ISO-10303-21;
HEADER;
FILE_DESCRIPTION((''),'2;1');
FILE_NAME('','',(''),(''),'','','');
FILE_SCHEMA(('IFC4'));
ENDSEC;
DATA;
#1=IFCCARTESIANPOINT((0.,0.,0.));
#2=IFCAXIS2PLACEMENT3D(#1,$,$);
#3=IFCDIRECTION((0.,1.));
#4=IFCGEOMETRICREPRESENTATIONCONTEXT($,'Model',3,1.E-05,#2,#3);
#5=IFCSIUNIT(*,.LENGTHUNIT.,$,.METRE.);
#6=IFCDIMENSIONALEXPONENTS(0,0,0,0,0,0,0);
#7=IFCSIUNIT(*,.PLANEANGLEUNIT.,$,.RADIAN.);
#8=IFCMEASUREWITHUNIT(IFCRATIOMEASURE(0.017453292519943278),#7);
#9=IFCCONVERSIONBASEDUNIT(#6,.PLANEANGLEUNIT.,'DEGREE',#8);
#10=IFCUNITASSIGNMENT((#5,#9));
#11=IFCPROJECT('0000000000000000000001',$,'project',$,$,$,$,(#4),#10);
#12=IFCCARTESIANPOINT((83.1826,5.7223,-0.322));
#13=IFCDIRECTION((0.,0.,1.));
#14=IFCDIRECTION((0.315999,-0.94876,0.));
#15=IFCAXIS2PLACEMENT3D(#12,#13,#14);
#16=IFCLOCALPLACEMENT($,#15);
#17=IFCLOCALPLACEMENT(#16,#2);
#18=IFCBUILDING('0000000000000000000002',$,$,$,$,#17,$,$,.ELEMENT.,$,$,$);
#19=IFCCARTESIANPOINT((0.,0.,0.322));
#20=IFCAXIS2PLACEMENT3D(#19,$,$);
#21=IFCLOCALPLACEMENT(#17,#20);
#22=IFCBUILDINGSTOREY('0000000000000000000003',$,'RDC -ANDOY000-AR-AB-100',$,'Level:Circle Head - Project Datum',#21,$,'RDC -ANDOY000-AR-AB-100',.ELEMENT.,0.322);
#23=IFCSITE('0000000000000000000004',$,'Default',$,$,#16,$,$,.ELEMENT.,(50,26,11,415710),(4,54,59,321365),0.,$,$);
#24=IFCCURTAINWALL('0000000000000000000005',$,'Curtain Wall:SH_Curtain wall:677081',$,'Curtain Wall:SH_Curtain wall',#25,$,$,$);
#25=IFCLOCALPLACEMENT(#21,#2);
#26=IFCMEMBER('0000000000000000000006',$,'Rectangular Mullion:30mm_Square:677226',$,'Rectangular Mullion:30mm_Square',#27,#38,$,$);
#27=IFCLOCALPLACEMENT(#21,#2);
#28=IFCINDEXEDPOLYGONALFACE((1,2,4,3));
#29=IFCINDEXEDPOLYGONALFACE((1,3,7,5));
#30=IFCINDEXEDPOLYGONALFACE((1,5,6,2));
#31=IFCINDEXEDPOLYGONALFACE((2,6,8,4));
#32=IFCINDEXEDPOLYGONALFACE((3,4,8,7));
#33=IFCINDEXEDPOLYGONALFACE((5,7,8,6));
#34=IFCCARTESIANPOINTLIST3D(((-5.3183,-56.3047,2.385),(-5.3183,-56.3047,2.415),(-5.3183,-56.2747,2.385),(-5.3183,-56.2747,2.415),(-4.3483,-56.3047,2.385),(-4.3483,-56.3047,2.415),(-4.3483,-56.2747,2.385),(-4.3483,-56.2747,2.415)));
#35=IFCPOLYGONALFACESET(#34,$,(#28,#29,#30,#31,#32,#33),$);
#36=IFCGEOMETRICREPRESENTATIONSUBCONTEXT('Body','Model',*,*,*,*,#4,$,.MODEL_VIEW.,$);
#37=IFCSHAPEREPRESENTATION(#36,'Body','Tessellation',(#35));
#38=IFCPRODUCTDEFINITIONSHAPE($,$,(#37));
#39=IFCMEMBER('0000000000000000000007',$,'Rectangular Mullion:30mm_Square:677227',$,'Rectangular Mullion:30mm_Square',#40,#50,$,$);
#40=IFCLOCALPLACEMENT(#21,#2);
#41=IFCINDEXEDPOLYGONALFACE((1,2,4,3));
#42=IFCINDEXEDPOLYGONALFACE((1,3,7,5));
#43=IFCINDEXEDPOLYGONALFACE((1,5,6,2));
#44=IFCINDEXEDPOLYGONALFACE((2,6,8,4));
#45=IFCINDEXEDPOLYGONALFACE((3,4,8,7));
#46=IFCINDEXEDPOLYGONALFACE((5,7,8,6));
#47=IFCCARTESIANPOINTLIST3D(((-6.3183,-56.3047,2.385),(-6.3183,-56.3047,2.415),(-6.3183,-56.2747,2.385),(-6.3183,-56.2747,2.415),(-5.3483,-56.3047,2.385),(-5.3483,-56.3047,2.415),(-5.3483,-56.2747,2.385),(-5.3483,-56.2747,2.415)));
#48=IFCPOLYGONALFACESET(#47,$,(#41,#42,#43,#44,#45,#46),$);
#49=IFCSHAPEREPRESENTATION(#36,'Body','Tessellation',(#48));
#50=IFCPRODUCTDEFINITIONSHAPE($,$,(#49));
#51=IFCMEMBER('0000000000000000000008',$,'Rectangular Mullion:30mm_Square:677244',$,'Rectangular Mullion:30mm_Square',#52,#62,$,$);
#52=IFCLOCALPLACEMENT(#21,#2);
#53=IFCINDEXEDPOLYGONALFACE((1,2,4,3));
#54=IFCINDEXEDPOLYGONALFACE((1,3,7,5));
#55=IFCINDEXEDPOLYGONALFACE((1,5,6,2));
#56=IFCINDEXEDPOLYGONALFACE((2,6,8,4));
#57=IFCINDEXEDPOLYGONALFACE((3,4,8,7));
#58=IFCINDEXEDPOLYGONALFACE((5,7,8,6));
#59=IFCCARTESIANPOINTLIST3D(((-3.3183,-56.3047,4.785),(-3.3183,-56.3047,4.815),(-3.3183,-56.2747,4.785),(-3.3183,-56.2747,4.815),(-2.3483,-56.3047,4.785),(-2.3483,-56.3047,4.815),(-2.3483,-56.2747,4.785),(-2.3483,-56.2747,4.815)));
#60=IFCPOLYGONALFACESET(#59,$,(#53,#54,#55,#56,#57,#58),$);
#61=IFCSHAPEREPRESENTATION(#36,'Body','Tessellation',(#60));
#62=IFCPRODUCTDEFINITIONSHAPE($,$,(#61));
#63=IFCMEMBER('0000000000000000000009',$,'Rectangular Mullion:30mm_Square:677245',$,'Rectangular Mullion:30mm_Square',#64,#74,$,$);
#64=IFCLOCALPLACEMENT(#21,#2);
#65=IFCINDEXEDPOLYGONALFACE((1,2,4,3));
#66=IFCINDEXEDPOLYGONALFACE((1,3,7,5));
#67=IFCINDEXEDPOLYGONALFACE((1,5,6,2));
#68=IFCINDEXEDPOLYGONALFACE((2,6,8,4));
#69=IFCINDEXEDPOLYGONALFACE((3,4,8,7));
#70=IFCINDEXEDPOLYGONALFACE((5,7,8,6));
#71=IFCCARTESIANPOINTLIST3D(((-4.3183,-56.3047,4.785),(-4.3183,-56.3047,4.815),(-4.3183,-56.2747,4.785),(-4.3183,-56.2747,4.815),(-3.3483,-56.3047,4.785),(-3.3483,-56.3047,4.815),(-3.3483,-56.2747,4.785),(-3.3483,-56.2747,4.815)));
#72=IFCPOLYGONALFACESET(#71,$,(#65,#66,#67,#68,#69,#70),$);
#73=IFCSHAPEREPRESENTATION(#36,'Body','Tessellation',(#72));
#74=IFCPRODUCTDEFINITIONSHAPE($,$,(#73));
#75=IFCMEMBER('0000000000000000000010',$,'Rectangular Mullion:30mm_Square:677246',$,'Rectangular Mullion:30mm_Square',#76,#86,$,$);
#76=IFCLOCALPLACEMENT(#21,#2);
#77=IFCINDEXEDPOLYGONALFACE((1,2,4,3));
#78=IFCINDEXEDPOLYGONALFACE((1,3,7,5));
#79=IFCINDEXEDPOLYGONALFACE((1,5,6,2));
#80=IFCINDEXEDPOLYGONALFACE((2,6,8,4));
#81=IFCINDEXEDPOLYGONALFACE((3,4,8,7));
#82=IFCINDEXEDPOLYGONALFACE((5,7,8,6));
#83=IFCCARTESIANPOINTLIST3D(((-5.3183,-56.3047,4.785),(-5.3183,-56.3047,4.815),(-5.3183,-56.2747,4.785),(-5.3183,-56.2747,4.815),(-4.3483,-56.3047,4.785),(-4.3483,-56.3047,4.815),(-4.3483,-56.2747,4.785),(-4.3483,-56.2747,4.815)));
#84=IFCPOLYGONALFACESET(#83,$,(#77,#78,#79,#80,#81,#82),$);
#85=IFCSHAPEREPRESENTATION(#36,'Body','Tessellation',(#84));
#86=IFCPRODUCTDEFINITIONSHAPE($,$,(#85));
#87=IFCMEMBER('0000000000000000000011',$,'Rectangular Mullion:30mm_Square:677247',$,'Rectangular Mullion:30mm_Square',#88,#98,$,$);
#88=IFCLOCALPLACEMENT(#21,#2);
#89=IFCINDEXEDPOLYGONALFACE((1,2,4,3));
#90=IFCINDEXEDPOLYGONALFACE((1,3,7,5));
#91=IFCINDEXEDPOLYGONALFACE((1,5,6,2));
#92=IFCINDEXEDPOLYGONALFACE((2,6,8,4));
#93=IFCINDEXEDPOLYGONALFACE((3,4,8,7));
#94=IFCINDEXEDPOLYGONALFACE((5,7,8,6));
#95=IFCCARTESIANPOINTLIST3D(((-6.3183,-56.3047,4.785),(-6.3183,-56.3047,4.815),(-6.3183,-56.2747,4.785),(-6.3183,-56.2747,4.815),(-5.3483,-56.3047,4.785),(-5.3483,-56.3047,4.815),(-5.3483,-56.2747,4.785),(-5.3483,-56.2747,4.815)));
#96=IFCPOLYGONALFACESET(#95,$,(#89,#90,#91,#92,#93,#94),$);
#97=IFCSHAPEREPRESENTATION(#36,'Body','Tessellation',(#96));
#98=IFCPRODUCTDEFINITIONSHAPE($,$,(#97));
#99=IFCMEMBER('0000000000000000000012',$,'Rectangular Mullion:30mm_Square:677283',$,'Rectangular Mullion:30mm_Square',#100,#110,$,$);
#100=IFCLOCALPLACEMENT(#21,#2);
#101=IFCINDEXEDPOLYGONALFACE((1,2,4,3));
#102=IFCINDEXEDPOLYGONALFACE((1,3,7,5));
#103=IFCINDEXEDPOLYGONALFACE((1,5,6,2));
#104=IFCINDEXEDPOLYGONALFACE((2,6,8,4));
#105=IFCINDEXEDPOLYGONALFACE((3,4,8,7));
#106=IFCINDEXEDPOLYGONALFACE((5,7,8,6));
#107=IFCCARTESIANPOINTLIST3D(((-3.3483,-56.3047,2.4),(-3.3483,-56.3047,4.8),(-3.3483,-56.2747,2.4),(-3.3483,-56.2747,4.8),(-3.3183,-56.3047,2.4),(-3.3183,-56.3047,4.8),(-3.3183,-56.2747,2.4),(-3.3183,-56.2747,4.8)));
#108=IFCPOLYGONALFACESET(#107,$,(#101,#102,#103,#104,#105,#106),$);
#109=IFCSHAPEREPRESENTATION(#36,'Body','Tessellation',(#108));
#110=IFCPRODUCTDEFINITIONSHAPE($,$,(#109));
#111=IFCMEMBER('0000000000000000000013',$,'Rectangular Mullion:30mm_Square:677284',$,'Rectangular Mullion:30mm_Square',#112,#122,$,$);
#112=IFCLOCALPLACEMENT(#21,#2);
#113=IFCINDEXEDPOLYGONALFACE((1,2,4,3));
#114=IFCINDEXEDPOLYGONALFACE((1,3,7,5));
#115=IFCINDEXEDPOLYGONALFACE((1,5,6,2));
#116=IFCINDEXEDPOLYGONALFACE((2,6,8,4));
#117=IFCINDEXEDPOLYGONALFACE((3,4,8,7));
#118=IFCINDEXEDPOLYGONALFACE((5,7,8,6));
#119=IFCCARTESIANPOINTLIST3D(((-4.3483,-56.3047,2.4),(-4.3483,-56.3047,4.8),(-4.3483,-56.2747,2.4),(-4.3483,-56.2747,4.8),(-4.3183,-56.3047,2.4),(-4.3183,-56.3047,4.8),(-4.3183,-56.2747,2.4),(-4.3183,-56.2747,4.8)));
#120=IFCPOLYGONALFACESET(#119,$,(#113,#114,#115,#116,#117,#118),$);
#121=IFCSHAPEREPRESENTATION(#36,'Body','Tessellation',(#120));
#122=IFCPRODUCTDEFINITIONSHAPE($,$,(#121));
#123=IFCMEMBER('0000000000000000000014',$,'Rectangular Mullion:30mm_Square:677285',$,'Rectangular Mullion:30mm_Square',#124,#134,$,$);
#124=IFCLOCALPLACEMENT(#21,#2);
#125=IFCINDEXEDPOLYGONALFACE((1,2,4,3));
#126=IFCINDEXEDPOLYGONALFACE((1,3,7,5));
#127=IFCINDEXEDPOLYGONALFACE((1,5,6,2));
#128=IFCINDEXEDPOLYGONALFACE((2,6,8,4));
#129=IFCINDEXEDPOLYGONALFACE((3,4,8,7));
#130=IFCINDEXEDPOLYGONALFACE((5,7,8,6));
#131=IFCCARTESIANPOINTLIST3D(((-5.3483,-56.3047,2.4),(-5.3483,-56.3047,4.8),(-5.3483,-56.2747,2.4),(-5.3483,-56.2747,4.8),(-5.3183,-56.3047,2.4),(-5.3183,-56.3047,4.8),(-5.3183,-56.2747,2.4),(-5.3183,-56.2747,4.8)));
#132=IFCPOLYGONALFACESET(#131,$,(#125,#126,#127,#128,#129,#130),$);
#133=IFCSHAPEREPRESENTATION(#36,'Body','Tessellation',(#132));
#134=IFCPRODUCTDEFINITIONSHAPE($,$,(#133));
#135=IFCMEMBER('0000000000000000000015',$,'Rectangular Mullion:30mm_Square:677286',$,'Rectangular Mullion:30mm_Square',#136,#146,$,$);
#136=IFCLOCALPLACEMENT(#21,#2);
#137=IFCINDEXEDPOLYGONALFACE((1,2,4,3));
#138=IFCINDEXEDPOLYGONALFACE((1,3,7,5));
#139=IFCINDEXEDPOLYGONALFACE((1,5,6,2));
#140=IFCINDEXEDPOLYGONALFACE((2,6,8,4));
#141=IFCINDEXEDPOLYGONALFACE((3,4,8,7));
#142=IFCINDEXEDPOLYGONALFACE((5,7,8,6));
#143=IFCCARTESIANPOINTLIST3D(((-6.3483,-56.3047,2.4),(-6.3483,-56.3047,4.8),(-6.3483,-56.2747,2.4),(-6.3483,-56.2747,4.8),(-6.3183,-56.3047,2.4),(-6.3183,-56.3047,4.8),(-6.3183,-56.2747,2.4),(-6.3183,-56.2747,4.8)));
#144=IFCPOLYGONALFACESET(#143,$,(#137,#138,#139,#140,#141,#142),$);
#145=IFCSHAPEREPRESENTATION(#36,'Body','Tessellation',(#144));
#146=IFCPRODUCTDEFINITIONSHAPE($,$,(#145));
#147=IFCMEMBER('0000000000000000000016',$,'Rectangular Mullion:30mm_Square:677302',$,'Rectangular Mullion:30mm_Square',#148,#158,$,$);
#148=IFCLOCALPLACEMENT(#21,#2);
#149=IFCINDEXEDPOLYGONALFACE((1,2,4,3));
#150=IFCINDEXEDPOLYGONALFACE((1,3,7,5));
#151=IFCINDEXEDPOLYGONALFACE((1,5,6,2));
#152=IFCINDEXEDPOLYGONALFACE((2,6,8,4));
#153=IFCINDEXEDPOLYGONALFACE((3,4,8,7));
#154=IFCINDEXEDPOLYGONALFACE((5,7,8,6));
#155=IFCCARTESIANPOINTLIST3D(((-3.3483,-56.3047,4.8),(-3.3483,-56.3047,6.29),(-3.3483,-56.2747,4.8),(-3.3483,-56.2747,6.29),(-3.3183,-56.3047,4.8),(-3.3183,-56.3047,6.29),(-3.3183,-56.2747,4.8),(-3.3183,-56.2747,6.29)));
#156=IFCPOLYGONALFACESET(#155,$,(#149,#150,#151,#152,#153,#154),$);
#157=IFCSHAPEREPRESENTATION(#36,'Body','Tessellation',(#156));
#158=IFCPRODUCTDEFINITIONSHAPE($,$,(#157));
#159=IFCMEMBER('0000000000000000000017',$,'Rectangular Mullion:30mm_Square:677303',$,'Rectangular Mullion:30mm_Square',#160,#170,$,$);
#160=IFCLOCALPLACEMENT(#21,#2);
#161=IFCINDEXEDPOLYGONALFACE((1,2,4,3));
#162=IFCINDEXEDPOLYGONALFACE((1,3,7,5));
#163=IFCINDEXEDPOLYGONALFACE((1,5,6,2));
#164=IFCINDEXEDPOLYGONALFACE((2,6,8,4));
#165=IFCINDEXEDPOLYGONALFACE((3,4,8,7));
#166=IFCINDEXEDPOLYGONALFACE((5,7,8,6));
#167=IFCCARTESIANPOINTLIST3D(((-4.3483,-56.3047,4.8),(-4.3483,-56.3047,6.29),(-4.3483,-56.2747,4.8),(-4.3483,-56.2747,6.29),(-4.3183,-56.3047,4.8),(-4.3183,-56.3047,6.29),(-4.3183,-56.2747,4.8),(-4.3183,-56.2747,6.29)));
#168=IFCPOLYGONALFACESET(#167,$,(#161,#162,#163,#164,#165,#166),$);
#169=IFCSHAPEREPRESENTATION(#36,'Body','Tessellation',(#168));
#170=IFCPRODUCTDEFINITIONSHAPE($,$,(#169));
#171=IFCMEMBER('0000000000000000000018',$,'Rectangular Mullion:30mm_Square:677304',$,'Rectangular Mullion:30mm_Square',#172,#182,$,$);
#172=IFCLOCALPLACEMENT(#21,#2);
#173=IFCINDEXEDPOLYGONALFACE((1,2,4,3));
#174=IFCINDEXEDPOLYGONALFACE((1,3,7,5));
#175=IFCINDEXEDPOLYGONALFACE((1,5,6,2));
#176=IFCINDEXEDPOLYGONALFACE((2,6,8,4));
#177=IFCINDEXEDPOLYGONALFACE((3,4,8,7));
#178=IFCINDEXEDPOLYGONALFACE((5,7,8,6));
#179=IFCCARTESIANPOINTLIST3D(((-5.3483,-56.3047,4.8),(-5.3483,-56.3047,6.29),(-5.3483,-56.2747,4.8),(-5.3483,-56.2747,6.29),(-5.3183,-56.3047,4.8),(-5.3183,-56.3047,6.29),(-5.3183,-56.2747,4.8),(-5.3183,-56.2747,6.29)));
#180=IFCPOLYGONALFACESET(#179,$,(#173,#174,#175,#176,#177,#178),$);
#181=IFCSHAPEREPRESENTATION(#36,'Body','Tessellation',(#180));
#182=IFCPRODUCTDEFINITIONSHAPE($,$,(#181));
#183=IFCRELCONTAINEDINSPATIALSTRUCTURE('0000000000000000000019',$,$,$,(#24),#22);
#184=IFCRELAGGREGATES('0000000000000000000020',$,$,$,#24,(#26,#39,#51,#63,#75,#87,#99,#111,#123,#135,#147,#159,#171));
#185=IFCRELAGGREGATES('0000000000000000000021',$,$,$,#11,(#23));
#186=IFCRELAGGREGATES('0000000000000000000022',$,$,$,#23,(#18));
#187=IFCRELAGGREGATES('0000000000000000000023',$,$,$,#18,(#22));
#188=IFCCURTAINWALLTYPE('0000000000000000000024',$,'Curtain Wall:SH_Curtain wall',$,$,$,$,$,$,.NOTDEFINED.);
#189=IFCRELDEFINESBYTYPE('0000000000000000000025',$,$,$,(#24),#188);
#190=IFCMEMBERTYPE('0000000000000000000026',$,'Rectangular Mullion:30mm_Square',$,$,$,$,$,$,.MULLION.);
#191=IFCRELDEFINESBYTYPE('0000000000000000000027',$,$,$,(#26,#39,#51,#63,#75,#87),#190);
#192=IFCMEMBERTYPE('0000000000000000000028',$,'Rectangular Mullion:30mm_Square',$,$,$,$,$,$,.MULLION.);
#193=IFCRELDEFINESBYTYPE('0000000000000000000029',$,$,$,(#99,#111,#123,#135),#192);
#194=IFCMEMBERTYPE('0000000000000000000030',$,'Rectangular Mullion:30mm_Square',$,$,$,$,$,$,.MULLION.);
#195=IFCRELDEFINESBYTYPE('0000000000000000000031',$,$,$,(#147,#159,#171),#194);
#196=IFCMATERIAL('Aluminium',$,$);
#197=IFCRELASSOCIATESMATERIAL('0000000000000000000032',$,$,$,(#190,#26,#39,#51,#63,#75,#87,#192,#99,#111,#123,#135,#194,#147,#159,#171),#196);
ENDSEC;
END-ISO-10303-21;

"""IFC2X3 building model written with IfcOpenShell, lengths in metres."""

from ifc_helpers import new_model, entity, si_unit, converted_unit, direction, frame, origin, origin_2d_with_axis, place, context, subcontext, project, spatial, rectangle, extrude, source, transform, mapped, material, type_object, type_shapes, element, aggregate, save


model = new_model("IFC2X3")

# Units and contexts
model_context = context("Model", 3, precision=1e-05, world=origin(), true_north=direction((0.0, 1.0)))
body_context = subcontext(model_context, "Body", "Model", "MODEL_VIEW")
ifc_project = project(units=[si_unit("LENGTHUNIT", "METRE"), converted_unit("PLANEANGLEUNIT", "DEGREE", entity("IfcRatioMeasure", 0.017453292519943278), si_unit("PLANEANGLEUNIT", "RADIAN"), dimensions=[0, 0, 0, 0, 0, 0, 0])], contexts=[model_context])

# Site, building, storey
site_placement = place(None, frame((83.1826, 5.7223, -0.322), z_axis=(0.0, 0.0, 1.0), x_axis=(0.315999, -0.94876, 0.0)))
site = spatial("IfcSite", under=ifc_project, at=site_placement, Name="Default", CompositionType="ELEMENT", RefLatitude=(50, 26, 11, 415710), RefLongitude=(4, 54, 59, 321365), RefElevation=0.0)
building_placement = place(site_placement, origin())
building = spatial("IfcBuilding", under=site, at=building_placement, CompositionType="ELEMENT")
storey_placement = place(building_placement, frame((0.0, 0.0, 0.322)))
storey = spatial("IfcBuildingStorey", under=building, at=storey_placement, Name="RDC -ANDOY000-AR-AB-100", ObjectType="Level:Circle Head - Project Datum", LongName="RDC -ANDOY000-AR-AB-100", CompositionType="ELEMENT", Elevation=0.322)

# Curtain wall, members
curtain_wall_type = type_object("IfcCurtainWallType", Name="Curtain Wall:SH_Curtain wall", PredefinedType="NOTDEFINED")
curtain_wall_placement = place(storey_placement, frame((0.0, 0.0, -0.322)))
curtain_wall = element("IfcCurtainWall", 1, at=curtain_wall_placement, inside=storey, type_object=curtain_wall_type, Name="Curtain Wall:SH_Curtain wall:677081", ObjectType="Curtain Wall:SH_Curtain wall")
ifc_material_1 = material(Name="Aluminium")
member_type_1 = type_object("IfcMemberType", Name="Rectangular Mullion:30mm_Square", PredefinedType="MULLION", material=ifc_material_1)
shared_shape_1 = source(origin(), body_context, "Body", "SweptSolid", [
    extrude(rectangle(XDim=0.03, YDim=0.03, at=origin_2d_with_axis()), frame((0.0, 0.0, -0.97), z_axis=(0.0, 0.0, 1.0), x_axis=(0.0, -1.0, 0.0)), (0.0, 0.0, 1.0), 0.97),
])
type_shapes(member_type_1, [shared_shape_1])
member_1_placement = place(curtain_wall_placement, frame((-5.3183, -56.2897, 2.722), z_axis=(-1.0, 0.0, 0.0), x_axis=(0.0, 0.0, 1.0)))
member_1 = element("IfcMember", 2, at=member_1_placement, type_object=member_type_1, material=ifc_material_1, Name="Rectangular Mullion:30mm_Square:677226", ObjectType="Rectangular Mullion:30mm_Square", context=body_context, shape_type="MappedRepresentation", body=[
    mapped(shared_shape_1, transform((0.0, 0.0, 0.0), scale=1.0)),
])
member_2_placement = place(curtain_wall_placement, frame((-6.3183, -56.2897, 2.722), z_axis=(-1.0, 0.0, 0.0), x_axis=(0.0, 0.0, 1.0)))
member_2 = element("IfcMember", 3, at=member_2_placement, type_object=member_type_1, material=ifc_material_1, Name="Rectangular Mullion:30mm_Square:677227", ObjectType="Rectangular Mullion:30mm_Square", context=body_context, shape_type="MappedRepresentation", body=[
    mapped(shared_shape_1, transform((0.0, 0.0, 0.0), scale=1.0)),
])
member_3_placement = place(curtain_wall_placement, frame((-3.3183, -56.2897, 5.122), z_axis=(-1.0, 0.0, 0.0), x_axis=(0.0, 0.0, 1.0)))
member_3 = element("IfcMember", 4, at=member_3_placement, type_object=member_type_1, material=ifc_material_1, Name="Rectangular Mullion:30mm_Square:677244", ObjectType="Rectangular Mullion:30mm_Square", context=body_context, shape_type="MappedRepresentation", body=[
    mapped(shared_shape_1, transform((0.0, 0.0, 0.0), scale=1.0)),
])
member_4_placement = place(curtain_wall_placement, frame((-4.3183, -56.2897, 5.122), z_axis=(-1.0, 0.0, 0.0), x_axis=(0.0, 0.0, 1.0)))
member_4 = element("IfcMember", 5, at=member_4_placement, type_object=member_type_1, material=ifc_material_1, Name="Rectangular Mullion:30mm_Square:677245", ObjectType="Rectangular Mullion:30mm_Square", context=body_context, shape_type="MappedRepresentation", body=[
    mapped(shared_shape_1, transform((0.0, 0.0, 0.0), scale=1.0)),
])
member_5_placement = place(curtain_wall_placement, frame((-5.3183, -56.2897, 5.122), z_axis=(-1.0, 0.0, 0.0), x_axis=(0.0, 0.0, 1.0)))
member_5 = element("IfcMember", 6, at=member_5_placement, type_object=member_type_1, material=ifc_material_1, Name="Rectangular Mullion:30mm_Square:677246", ObjectType="Rectangular Mullion:30mm_Square", context=body_context, shape_type="MappedRepresentation", body=[
    mapped(shared_shape_1, transform((0.0, 0.0, 0.0), scale=1.0)),
])
member_6_placement = place(curtain_wall_placement, frame((-6.3183, -56.2897, 5.122), z_axis=(-1.0, 0.0, 0.0), x_axis=(0.0, 0.0, 1.0)))
member_6 = element("IfcMember", 7, at=member_6_placement, type_object=member_type_1, material=ifc_material_1, Name="Rectangular Mullion:30mm_Square:677247", ObjectType="Rectangular Mullion:30mm_Square", context=body_context, shape_type="MappedRepresentation", body=[
    mapped(shared_shape_1, transform((0.0, 0.0, 0.0), scale=1.0)),
])
member_type_2 = type_object("IfcMemberType", Name="Rectangular Mullion:30mm_Square", PredefinedType="MULLION", material=ifc_material_1)
shared_shape_2 = source(origin(), body_context, "Body", "SweptSolid", [
    extrude(rectangle(XDim=0.03, YDim=0.03, at=origin_2d_with_axis()), frame((0.0, 0.0, -2.4), z_axis=(0.0, 0.0, 1.0), x_axis=(0.0, -1.0, 0.0)), (0.0, 0.0, 1.0), 2.4),
])
type_shapes(member_type_2, [shared_shape_2])
member_7_placement = place(curtain_wall_placement, frame((-3.3333, -56.2897, 2.722), z_axis=(0.0, 0.0, -1.0), x_axis=(-1.0, 0.0, 0.0)))
member_7 = element("IfcMember", 8, at=member_7_placement, type_object=member_type_2, material=ifc_material_1, Name="Rectangular Mullion:30mm_Square:677283", ObjectType="Rectangular Mullion:30mm_Square", context=body_context, shape_type="MappedRepresentation", body=[
    mapped(shared_shape_2, transform((0.0, 0.0, 0.0), scale=1.0)),
])
member_8_placement = place(curtain_wall_placement, frame((-4.3333, -56.2897, 2.722), z_axis=(0.0, 0.0, -1.0), x_axis=(-1.0, 0.0, 0.0)))
member_8 = element("IfcMember", 9, at=member_8_placement, type_object=member_type_2, material=ifc_material_1, Name="Rectangular Mullion:30mm_Square:677284", ObjectType="Rectangular Mullion:30mm_Square", context=body_context, shape_type="MappedRepresentation", body=[
    mapped(shared_shape_2, transform((0.0, 0.0, 0.0), scale=1.0)),
])
member_9_placement = place(curtain_wall_placement, frame((-5.3333, -56.2897, 2.722), z_axis=(0.0, 0.0, -1.0), x_axis=(-1.0, 0.0, 0.0)))
member_9 = element("IfcMember", 10, at=member_9_placement, type_object=member_type_2, material=ifc_material_1, Name="Rectangular Mullion:30mm_Square:677285", ObjectType="Rectangular Mullion:30mm_Square", context=body_context, shape_type="MappedRepresentation", body=[
    mapped(shared_shape_2, transform((0.0, 0.0, 0.0), scale=1.0)),
])
member_10_placement = place(curtain_wall_placement, frame((-6.3333, -56.2897, 2.722), z_axis=(0.0, 0.0, -1.0), x_axis=(-1.0, 0.0, 0.0)))
member_10 = element("IfcMember", 11, at=member_10_placement, type_object=member_type_2, material=ifc_material_1, Name="Rectangular Mullion:30mm_Square:677286", ObjectType="Rectangular Mullion:30mm_Square", context=body_context, shape_type="MappedRepresentation", body=[
    mapped(shared_shape_2, transform((0.0, 0.0, 0.0), scale=1.0)),
])
member_type_3 = type_object("IfcMemberType", Name="Rectangular Mullion:30mm_Square", PredefinedType="MULLION", material=ifc_material_1)
shared_shape_3 = source(origin(), body_context, "Body", "SweptSolid", [
    extrude(rectangle(XDim=0.03, YDim=0.03, at=origin_2d_with_axis()), frame((0.0, 0.0, -1.49), z_axis=(0.0, 0.0, 1.0), x_axis=(0.0, -1.0, 0.0)), (0.0, 0.0, 1.0), 1.49),
])
type_shapes(member_type_3, [shared_shape_3])
member_11_placement = place(curtain_wall_placement, frame((-3.3333, -56.2897, 5.122), z_axis=(0.0, 0.0, -1.0), x_axis=(-1.0, 0.0, 0.0)))
member_11 = element("IfcMember", 12, at=member_11_placement, type_object=member_type_3, material=ifc_material_1, Name="Rectangular Mullion:30mm_Square:677302", ObjectType="Rectangular Mullion:30mm_Square", context=body_context, shape_type="MappedRepresentation", body=[
    mapped(shared_shape_3, transform((0.0, 0.0, 0.0), scale=1.0)),
])
member_12_placement = place(curtain_wall_placement, frame((-4.3333, -56.2897, 5.122), z_axis=(0.0, 0.0, -1.0), x_axis=(-1.0, 0.0, 0.0)))
member_12 = element("IfcMember", 13, at=member_12_placement, type_object=member_type_3, material=ifc_material_1, Name="Rectangular Mullion:30mm_Square:677303", ObjectType="Rectangular Mullion:30mm_Square", context=body_context, shape_type="MappedRepresentation", body=[
    mapped(shared_shape_3, transform((0.0, 0.0, 0.0), scale=1.0)),
])
member_13_placement = place(curtain_wall_placement, frame((-5.3333, -56.2897, 5.122), z_axis=(0.0, 0.0, -1.0), x_axis=(-1.0, 0.0, 0.0)))
member_13 = element("IfcMember", 14, at=member_13_placement, type_object=member_type_3, material=ifc_material_1, Name="Rectangular Mullion:30mm_Square:677304", ObjectType="Rectangular Mullion:30mm_Square", context=body_context, shape_type="MappedRepresentation", body=[
    mapped(shared_shape_3, transform((0.0, 0.0, 0.0), scale=1.0)),
])
aggregate(curtain_wall, [member_1, member_2, member_3, member_4, member_5, member_6, member_7, member_8, member_9, member_10, member_11, member_12, member_13])

save(model, "model.ifc")
